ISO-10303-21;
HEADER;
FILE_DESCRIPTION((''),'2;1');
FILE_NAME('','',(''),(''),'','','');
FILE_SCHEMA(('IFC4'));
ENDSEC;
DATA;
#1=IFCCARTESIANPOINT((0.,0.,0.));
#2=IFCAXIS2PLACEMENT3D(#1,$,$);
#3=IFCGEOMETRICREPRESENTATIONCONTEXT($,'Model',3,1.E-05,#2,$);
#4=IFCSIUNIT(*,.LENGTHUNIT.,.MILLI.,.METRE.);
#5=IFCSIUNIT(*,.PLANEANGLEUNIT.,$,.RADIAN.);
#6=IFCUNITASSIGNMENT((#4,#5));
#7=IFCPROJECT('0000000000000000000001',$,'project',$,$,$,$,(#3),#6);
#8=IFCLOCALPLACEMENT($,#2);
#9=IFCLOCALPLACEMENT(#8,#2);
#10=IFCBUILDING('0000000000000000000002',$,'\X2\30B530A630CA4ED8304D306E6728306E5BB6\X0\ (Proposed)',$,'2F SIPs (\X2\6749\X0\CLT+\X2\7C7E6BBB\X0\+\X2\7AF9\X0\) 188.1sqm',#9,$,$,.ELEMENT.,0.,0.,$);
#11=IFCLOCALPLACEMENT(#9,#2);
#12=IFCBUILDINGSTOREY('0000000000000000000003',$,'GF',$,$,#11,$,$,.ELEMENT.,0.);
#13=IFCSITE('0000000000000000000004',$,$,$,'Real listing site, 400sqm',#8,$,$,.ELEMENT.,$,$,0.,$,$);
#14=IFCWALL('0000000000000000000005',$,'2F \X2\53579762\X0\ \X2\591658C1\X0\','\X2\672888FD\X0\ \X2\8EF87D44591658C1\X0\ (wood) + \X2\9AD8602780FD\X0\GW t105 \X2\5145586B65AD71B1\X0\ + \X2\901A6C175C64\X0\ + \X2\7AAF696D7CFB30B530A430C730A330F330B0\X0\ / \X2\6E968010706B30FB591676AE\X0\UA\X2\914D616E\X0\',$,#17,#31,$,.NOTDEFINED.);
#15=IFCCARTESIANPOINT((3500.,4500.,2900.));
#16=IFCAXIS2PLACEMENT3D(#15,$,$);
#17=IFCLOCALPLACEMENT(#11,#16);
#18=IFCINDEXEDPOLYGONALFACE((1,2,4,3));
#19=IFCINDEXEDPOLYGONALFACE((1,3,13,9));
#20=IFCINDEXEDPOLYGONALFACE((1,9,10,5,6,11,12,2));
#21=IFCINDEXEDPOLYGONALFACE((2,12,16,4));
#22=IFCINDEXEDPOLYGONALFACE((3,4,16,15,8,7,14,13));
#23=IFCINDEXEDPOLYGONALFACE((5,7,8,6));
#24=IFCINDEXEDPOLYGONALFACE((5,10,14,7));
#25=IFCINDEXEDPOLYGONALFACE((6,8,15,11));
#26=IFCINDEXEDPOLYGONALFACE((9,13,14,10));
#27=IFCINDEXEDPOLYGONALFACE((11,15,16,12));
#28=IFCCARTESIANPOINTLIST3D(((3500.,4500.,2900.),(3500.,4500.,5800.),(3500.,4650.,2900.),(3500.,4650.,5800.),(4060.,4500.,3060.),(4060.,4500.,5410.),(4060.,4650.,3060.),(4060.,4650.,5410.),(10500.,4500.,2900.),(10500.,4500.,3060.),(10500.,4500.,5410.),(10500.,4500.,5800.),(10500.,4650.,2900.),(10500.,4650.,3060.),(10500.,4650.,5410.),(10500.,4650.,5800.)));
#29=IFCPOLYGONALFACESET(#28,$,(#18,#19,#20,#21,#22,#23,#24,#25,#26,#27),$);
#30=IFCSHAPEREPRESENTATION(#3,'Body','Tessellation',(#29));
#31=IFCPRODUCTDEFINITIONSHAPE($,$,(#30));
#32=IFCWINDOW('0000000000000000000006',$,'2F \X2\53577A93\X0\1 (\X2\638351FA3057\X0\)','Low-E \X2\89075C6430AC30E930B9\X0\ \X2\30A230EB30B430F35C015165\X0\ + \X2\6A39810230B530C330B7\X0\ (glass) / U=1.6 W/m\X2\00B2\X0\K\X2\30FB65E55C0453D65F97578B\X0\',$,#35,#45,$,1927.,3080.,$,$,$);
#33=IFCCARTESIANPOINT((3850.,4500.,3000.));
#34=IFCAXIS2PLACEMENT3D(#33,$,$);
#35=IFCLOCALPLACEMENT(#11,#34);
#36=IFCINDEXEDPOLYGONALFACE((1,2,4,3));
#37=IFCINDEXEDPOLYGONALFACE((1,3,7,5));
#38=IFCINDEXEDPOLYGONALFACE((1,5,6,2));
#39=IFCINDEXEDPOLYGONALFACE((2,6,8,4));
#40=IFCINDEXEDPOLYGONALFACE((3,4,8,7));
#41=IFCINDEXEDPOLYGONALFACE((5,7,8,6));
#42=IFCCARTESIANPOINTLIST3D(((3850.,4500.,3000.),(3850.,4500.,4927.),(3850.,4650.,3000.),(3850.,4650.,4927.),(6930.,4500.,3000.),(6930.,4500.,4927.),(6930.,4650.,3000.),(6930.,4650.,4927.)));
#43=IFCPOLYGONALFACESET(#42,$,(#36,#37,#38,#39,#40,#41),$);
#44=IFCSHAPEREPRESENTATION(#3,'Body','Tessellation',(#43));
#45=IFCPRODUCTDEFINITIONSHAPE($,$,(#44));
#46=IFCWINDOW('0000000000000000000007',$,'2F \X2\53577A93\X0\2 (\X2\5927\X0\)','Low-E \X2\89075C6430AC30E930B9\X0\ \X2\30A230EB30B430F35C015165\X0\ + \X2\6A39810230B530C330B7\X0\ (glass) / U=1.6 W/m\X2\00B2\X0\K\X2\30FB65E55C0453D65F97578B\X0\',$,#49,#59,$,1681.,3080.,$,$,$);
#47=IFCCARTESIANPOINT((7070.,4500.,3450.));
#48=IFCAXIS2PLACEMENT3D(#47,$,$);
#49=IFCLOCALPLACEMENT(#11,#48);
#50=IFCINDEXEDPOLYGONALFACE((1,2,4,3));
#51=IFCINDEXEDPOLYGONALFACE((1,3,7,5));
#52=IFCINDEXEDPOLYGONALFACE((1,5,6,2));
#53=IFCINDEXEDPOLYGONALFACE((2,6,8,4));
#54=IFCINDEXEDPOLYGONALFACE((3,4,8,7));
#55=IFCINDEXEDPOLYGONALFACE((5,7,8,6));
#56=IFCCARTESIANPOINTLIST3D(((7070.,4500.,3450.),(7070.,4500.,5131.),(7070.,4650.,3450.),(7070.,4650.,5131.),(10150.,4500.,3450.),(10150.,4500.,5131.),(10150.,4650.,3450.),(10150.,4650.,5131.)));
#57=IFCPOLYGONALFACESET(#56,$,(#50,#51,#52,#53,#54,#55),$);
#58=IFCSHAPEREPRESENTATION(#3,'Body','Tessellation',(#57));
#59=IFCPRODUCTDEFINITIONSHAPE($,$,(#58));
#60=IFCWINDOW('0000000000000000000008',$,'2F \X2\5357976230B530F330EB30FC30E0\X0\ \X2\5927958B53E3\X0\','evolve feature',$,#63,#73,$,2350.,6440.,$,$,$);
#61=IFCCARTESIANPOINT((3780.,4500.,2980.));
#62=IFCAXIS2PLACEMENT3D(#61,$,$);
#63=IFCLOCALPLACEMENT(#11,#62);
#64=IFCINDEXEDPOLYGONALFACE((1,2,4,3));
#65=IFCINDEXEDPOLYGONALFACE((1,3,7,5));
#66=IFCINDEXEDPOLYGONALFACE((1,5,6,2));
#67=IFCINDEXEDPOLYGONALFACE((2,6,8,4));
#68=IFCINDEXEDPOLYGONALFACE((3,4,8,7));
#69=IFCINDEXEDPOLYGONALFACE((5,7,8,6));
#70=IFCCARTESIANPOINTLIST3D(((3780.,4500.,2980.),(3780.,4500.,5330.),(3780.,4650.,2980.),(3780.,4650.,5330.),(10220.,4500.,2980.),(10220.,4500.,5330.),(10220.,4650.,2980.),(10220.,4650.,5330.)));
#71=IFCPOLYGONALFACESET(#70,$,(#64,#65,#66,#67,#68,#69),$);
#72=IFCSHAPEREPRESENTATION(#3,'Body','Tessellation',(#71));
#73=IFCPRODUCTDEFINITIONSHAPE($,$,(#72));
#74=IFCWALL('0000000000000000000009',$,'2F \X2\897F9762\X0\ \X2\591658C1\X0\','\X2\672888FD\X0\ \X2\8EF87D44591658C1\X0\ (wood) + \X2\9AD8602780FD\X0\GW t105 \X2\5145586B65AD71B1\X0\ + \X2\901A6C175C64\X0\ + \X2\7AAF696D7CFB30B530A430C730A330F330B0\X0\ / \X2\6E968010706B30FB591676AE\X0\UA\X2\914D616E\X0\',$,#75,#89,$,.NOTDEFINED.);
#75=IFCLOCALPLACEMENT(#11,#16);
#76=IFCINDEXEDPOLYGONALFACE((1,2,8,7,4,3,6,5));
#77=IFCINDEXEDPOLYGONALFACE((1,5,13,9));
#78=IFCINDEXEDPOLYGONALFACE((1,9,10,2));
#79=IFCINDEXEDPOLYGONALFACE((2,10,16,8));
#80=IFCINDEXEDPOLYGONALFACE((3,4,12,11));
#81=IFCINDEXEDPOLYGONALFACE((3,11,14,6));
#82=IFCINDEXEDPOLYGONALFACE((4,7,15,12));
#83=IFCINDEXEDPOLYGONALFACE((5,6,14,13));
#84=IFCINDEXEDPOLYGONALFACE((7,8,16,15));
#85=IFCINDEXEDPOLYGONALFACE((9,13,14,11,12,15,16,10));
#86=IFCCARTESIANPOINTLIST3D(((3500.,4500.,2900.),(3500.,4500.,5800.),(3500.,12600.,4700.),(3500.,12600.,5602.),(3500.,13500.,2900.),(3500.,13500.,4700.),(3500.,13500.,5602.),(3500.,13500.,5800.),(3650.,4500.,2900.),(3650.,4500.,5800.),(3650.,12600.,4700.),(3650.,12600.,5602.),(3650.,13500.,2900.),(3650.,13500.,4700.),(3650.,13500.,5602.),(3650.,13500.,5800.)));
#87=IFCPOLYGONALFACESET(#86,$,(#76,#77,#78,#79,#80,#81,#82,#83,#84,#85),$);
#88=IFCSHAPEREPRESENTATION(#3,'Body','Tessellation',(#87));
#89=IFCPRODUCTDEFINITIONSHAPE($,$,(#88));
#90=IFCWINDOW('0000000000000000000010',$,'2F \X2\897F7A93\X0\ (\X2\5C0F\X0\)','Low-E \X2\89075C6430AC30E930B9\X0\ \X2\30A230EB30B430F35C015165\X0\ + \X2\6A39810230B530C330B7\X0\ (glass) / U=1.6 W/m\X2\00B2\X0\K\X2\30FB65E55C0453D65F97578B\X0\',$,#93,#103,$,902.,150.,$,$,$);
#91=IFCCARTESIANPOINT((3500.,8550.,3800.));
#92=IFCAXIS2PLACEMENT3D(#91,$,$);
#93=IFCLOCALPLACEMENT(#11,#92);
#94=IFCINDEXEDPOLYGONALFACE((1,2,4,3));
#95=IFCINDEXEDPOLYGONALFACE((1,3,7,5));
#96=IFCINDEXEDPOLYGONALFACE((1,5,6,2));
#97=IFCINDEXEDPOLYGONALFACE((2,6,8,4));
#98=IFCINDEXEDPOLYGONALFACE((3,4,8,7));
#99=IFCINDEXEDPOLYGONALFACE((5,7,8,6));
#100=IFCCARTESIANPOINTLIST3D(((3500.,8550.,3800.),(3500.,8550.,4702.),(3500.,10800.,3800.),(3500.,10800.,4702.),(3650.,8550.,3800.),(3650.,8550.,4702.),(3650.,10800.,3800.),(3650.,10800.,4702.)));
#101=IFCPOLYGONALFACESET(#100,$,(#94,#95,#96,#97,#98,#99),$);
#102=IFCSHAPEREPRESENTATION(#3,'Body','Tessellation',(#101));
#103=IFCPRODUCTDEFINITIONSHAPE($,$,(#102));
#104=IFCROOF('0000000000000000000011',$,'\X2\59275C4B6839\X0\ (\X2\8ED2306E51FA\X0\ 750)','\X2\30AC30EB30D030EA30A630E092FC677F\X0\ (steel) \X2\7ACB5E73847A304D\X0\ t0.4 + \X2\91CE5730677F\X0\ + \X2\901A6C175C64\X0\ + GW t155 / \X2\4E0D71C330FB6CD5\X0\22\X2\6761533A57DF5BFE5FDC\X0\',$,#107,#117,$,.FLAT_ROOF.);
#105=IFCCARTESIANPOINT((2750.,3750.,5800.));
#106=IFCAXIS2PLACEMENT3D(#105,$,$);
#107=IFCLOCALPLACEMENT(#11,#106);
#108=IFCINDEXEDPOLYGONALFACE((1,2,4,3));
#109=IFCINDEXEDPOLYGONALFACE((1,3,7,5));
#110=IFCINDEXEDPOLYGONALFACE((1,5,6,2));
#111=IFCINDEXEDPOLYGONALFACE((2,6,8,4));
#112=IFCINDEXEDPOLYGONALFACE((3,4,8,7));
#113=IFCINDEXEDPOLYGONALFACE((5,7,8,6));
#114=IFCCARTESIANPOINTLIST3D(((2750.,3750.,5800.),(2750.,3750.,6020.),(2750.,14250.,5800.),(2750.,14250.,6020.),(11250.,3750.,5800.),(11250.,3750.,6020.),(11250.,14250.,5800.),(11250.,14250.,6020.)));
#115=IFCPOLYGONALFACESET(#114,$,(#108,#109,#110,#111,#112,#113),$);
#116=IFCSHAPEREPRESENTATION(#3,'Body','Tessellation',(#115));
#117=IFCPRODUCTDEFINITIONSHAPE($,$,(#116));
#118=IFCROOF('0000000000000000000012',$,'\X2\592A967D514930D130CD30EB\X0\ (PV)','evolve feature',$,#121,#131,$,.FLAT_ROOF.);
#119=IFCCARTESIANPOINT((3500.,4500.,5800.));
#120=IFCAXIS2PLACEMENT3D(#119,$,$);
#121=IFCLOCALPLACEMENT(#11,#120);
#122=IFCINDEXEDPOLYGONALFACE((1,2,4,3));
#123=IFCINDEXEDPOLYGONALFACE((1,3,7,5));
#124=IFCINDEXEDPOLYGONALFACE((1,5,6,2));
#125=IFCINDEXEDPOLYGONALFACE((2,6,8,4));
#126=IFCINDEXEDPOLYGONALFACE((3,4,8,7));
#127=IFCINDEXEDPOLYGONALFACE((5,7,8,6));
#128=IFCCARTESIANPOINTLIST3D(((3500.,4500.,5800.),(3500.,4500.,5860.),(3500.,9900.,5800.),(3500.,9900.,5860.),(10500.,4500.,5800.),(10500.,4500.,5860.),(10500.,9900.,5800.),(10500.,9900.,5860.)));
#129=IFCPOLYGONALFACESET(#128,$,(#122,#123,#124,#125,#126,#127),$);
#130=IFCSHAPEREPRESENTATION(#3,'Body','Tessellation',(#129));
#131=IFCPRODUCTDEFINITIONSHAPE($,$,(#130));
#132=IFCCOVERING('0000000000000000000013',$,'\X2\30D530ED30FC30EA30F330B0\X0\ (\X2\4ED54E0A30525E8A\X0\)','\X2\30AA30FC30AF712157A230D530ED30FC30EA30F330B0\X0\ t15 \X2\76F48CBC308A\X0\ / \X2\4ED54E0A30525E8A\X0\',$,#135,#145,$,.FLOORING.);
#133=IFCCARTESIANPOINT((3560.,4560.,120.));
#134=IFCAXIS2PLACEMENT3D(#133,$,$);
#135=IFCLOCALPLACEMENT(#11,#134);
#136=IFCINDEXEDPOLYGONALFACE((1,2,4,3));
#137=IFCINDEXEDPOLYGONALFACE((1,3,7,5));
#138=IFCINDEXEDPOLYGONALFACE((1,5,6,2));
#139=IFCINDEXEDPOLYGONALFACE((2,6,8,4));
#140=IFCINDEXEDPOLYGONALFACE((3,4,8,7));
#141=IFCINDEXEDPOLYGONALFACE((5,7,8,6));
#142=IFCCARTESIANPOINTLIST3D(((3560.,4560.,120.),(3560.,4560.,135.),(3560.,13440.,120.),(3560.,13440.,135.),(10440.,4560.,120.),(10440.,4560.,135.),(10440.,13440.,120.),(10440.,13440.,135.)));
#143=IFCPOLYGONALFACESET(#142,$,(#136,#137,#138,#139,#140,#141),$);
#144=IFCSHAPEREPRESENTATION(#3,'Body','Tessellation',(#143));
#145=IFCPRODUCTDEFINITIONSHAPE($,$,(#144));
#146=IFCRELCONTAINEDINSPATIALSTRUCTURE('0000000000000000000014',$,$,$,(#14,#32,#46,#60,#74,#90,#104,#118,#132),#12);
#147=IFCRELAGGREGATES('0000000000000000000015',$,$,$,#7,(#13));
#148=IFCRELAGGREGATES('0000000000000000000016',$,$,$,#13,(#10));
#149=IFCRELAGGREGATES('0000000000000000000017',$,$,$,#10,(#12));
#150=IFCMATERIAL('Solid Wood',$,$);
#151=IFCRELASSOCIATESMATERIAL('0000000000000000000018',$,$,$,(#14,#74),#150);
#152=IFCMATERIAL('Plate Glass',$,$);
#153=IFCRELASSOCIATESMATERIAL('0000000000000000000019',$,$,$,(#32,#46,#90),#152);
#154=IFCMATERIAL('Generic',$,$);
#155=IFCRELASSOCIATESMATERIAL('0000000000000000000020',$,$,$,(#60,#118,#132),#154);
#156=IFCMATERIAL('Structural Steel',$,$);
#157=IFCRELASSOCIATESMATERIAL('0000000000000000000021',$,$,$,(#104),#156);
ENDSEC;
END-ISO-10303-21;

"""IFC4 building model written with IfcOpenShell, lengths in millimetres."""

from ifc_helpers import new_model, si_unit, frame, frame_2d, origin, place, context, project, spatial, rectangle, extrude, material, element, fill, save


model = new_model("IFC4")

# Units and contexts
model_context = context("Model", 3, precision=1e-05, world=origin())
ifc_project = project(units=[si_unit("LENGTHUNIT", "METRE", prefix="MILLI"), si_unit("PLANEANGLEUNIT", "RADIAN")], contexts=[model_context])

# Site, building, storey
site_placement = place(None, origin())
site = spatial("IfcSite", under=ifc_project, at=site_placement, ObjectType="Real listing site, 400sqm", CompositionType="ELEMENT", RefElevation=0.0)
building_placement = place(site_placement, origin())
building = spatial("IfcBuilding", under=site, at=building_placement, Name="サウナ付きの木の家 (Proposed)", ObjectType="2F SIPs (杉CLT+籾殻+竹) 188.1sqm", CompositionType="ELEMENT", ElevationOfRefHeight=0.0, ElevationOfTerrain=0.0)
storey_placement = place(building_placement, origin())
storey = spatial("IfcBuildingStorey", under=building, at=storey_placement, Name="GF", CompositionType="ELEMENT", Elevation=0.0)

# Shared definitions
ifc_material_1 = material(Name="Solid Wood")

# Shared definitions
ifc_material_2 = material(Name="Plate Glass")
ifc_material_3 = material(Name="Generic")

# Wall, openings, windows
wall_1_placement = place(storey_placement, frame((3500.0, 4500.0, 2900.0)))
wall_1 = element("IfcWall", 1, at=wall_1_placement, inside=storey, material=ifc_material_1, Name="2F 南面 外壁", Description="木製 軸組外壁 (wood) + 高性能GW t105 充填断熱 + 通気層 + 窯業系サイディング / 準耐火・外皮UA配慮", PredefinedType="NOTDEFINED", context=model_context, shape_type="SweptSolid", body=[
    extrude(rectangle(XDim=7000.0, YDim=150.0, at=frame_2d((3500.0, 75.0))), frame((3500.0, 4500.0, 2900.0)), (0.0, 0.0, 1.0), 2900.0),
])
opening_1_placement = place(storey_placement, frame((3850.0, 4500.0, 3000.0)))
opening_1 = element("IfcOpeningElement", 2, at=opening_1_placement, cuts=wall_1, PredefinedType="NOTDEFINED", context=model_context, shape_type="SweptSolid", body=[
    extrude(rectangle(XDim=3080.0, YDim=150.0, at=frame_2d((1540.0, 75.0))), frame((3850.0, 4500.0, 3000.0)), (0.0, 0.0, 1.0), 1927.0),
])
opening_2_placement = place(storey_placement, frame((7070.0, 4500.0, 3450.0)))
opening_2 = element("IfcOpeningElement", 3, at=opening_2_placement, cuts=wall_1, PredefinedType="NOTDEFINED", context=model_context, shape_type="SweptSolid", body=[
    extrude(rectangle(XDim=3080.0, YDim=150.0, at=frame_2d((1540.0, 75.0))), frame((7070.0, 4500.0, 3450.0)), (0.0, 0.0, 1.0), 1681.0),
])
opening_3_placement = place(storey_placement, frame((3780.0, 4500.0, 2980.0)))
opening_3 = element("IfcOpeningElement", 4, at=opening_3_placement, cuts=wall_1, PredefinedType="NOTDEFINED", context=model_context, shape_type="SweptSolid", body=[
    extrude(rectangle(XDim=6440.0, YDim=150.0, at=frame_2d((3220.0, 75.0))), frame((3780.0, 4500.0, 2980.0)), (0.0, 0.0, 1.0), 2350.0),
])
window_1_placement = place(storey_placement, frame((3850.0, 4500.0, 3000.0)))
window_1 = element("IfcWindow", 5, at=window_1_placement, inside=storey, material=ifc_material_2, Name="2F 南窓1 (掃出し)", Description="Low-E 複層ガラス アルゴン封入 + 樹脂サッシ (glass) / U=1.6 W/m²K・日射取得型", OverallHeight=1927.0, OverallWidth=3080.0, context=model_context, shape_type="SweptSolid", body=[
    extrude(rectangle(XDim=3080.0, YDim=150.0, at=frame_2d((1540.0, 75.0))), frame((3850.0, 4500.0, 3000.0)), (0.0, 0.0, 1.0), 1927.0),
])
fill(opening_1, window_1)
window_2_placement = place(storey_placement, frame((7070.0, 4500.0, 3450.0)))
window_2 = element("IfcWindow", 6, at=window_2_placement, inside=storey, material=ifc_material_2, Name="2F 南窓2 (大)", Description="Low-E 複層ガラス アルゴン封入 + 樹脂サッシ (glass) / U=1.6 W/m²K・日射取得型", OverallHeight=1681.0, OverallWidth=3080.0, context=model_context, shape_type="SweptSolid", body=[
    extrude(rectangle(XDim=3080.0, YDim=150.0, at=frame_2d((1540.0, 75.0))), frame((7070.0, 4500.0, 3450.0)), (0.0, 0.0, 1.0), 1681.0),
])
fill(opening_2, window_2)
window_3_placement = place(storey_placement, frame((3780.0, 4500.0, 2980.0)))
window_3 = element("IfcWindow", 7, at=window_3_placement, inside=storey, material=ifc_material_3, Name="2F 南面サンルーム 大開口", Description="evolve feature", OverallHeight=2350.0, OverallWidth=6440.0, context=model_context, shape_type="SweptSolid", body=[
    extrude(rectangle(XDim=6440.0, YDim=150.0, at=frame_2d((3220.0, 75.0))), frame((3780.0, 4500.0, 2980.0)), (0.0, 0.0, 1.0), 2350.0),
])
fill(opening_3, window_3)

# Wall, opening, window
wall_2_placement = place(storey_placement, frame((3500.0, 4500.0, 2900.0)))
wall_2 = element("IfcWall", 8, at=wall_2_placement, inside=storey, material=ifc_material_1, Name="2F 西面 外壁", Description="木製 軸組外壁 (wood) + 高性能GW t105 充填断熱 + 通気層 + 窯業系サイディング / 準耐火・外皮UA配慮", PredefinedType="NOTDEFINED", context=model_context, shape_type="SweptSolid", body=[
    extrude(rectangle(XDim=150.0, YDim=9000.0, at=frame_2d((75.0, 4500.0))), frame((3500.0, 4500.0, 2900.0)), (0.0, 0.0, 1.0), 2900.0),
])
opening_4_placement = place(storey_placement, frame((3500.0, 8550.0, 3800.0)))
opening_4 = element("IfcOpeningElement", 9, at=opening_4_placement, cuts=wall_2, PredefinedType="NOTDEFINED", context=model_context, shape_type="SweptSolid", body=[
    extrude(rectangle(XDim=150.0, YDim=2250.0, at=frame_2d((75.0, 1125.0))), frame((3500.0, 8550.0, 3800.0)), (0.0, 0.0, 1.0), 902.0),
])
window_4_placement = place(storey_placement, frame((3500.0, 8550.0, 3800.0)))
window_4 = element("IfcWindow", 10, at=window_4_placement, inside=storey, material=ifc_material_2, Name="2F 西窓 (小)", Description="Low-E 複層ガラス アルゴン封入 + 樹脂サッシ (glass) / U=1.6 W/m²K・日射取得型", OverallHeight=902.0, OverallWidth=150.0, context=model_context, shape_type="SweptSolid", body=[
    extrude(rectangle(XDim=150.0, YDim=2250.0, at=frame_2d((75.0, 1125.0))), frame((3500.0, 8550.0, 3800.0)), (0.0, 0.0, 1.0), 902.0),
])
fill(opening_4, window_4)

# Roofs
ifc_material_4 = material(Name="Structural Steel")
roof_1_placement = place(storey_placement, frame((2750.0, 3750.0, 5800.0)))
element("IfcRoof", 11, at=roof_1_placement, inside=storey, material=ifc_material_4, Name="大屋根 (軒の出 750)", Description="ガルバリウム鋼板 (steel) 立平葺き t0.4 + 野地板 + 通気層 + GW t155 / 不燃・法22条区域対応", PredefinedType="FLAT_ROOF", context=model_context, shape_type="SweptSolid", body=[
    extrude(rectangle(XDim=8500.0, YDim=10500.0, at=frame_2d((4250.0, 5250.0))), frame((2750.0, 3750.0, 5800.0)), (0.0, 0.0, 1.0), 220.0),
])
roof_2_placement = place(storey_placement, frame((3500.0, 4500.0, 5800.0)))
element("IfcRoof", 12, at=roof_2_placement, inside=storey, material=ifc_material_3, Name="太陽光パネル (PV)", Description="evolve feature", PredefinedType="FLAT_ROOF", context=model_context, shape_type="SweptSolid", body=[
    extrude(rectangle(XDim=7000.0, YDim=5400.0, at=frame_2d((3500.0, 2700.0))), frame((3500.0, 4500.0, 5800.0)), (0.0, 0.0, 1.0), 60.0),
])

# Covering
covering_placement = place(storey_placement, frame((3560.0, 4560.0, 120.0)))
element("IfcCovering", 13, at=covering_placement, inside=storey, material=ifc_material_3, Name="フローリング (仕上げ床)", Description="オーク無垢フローリング t15 直貼り / 仕上げ床", PredefinedType="FLOORING", context=model_context, shape_type="SweptSolid", body=[
    extrude(rectangle(XDim=6880.0, YDim=8880.0, at=frame_2d((3440.0, 4440.0))), frame((3560.0, 4560.0, 120.0)), (0.0, 0.0, 1.0), 15.0),
])

save(model, "model.ifc")
